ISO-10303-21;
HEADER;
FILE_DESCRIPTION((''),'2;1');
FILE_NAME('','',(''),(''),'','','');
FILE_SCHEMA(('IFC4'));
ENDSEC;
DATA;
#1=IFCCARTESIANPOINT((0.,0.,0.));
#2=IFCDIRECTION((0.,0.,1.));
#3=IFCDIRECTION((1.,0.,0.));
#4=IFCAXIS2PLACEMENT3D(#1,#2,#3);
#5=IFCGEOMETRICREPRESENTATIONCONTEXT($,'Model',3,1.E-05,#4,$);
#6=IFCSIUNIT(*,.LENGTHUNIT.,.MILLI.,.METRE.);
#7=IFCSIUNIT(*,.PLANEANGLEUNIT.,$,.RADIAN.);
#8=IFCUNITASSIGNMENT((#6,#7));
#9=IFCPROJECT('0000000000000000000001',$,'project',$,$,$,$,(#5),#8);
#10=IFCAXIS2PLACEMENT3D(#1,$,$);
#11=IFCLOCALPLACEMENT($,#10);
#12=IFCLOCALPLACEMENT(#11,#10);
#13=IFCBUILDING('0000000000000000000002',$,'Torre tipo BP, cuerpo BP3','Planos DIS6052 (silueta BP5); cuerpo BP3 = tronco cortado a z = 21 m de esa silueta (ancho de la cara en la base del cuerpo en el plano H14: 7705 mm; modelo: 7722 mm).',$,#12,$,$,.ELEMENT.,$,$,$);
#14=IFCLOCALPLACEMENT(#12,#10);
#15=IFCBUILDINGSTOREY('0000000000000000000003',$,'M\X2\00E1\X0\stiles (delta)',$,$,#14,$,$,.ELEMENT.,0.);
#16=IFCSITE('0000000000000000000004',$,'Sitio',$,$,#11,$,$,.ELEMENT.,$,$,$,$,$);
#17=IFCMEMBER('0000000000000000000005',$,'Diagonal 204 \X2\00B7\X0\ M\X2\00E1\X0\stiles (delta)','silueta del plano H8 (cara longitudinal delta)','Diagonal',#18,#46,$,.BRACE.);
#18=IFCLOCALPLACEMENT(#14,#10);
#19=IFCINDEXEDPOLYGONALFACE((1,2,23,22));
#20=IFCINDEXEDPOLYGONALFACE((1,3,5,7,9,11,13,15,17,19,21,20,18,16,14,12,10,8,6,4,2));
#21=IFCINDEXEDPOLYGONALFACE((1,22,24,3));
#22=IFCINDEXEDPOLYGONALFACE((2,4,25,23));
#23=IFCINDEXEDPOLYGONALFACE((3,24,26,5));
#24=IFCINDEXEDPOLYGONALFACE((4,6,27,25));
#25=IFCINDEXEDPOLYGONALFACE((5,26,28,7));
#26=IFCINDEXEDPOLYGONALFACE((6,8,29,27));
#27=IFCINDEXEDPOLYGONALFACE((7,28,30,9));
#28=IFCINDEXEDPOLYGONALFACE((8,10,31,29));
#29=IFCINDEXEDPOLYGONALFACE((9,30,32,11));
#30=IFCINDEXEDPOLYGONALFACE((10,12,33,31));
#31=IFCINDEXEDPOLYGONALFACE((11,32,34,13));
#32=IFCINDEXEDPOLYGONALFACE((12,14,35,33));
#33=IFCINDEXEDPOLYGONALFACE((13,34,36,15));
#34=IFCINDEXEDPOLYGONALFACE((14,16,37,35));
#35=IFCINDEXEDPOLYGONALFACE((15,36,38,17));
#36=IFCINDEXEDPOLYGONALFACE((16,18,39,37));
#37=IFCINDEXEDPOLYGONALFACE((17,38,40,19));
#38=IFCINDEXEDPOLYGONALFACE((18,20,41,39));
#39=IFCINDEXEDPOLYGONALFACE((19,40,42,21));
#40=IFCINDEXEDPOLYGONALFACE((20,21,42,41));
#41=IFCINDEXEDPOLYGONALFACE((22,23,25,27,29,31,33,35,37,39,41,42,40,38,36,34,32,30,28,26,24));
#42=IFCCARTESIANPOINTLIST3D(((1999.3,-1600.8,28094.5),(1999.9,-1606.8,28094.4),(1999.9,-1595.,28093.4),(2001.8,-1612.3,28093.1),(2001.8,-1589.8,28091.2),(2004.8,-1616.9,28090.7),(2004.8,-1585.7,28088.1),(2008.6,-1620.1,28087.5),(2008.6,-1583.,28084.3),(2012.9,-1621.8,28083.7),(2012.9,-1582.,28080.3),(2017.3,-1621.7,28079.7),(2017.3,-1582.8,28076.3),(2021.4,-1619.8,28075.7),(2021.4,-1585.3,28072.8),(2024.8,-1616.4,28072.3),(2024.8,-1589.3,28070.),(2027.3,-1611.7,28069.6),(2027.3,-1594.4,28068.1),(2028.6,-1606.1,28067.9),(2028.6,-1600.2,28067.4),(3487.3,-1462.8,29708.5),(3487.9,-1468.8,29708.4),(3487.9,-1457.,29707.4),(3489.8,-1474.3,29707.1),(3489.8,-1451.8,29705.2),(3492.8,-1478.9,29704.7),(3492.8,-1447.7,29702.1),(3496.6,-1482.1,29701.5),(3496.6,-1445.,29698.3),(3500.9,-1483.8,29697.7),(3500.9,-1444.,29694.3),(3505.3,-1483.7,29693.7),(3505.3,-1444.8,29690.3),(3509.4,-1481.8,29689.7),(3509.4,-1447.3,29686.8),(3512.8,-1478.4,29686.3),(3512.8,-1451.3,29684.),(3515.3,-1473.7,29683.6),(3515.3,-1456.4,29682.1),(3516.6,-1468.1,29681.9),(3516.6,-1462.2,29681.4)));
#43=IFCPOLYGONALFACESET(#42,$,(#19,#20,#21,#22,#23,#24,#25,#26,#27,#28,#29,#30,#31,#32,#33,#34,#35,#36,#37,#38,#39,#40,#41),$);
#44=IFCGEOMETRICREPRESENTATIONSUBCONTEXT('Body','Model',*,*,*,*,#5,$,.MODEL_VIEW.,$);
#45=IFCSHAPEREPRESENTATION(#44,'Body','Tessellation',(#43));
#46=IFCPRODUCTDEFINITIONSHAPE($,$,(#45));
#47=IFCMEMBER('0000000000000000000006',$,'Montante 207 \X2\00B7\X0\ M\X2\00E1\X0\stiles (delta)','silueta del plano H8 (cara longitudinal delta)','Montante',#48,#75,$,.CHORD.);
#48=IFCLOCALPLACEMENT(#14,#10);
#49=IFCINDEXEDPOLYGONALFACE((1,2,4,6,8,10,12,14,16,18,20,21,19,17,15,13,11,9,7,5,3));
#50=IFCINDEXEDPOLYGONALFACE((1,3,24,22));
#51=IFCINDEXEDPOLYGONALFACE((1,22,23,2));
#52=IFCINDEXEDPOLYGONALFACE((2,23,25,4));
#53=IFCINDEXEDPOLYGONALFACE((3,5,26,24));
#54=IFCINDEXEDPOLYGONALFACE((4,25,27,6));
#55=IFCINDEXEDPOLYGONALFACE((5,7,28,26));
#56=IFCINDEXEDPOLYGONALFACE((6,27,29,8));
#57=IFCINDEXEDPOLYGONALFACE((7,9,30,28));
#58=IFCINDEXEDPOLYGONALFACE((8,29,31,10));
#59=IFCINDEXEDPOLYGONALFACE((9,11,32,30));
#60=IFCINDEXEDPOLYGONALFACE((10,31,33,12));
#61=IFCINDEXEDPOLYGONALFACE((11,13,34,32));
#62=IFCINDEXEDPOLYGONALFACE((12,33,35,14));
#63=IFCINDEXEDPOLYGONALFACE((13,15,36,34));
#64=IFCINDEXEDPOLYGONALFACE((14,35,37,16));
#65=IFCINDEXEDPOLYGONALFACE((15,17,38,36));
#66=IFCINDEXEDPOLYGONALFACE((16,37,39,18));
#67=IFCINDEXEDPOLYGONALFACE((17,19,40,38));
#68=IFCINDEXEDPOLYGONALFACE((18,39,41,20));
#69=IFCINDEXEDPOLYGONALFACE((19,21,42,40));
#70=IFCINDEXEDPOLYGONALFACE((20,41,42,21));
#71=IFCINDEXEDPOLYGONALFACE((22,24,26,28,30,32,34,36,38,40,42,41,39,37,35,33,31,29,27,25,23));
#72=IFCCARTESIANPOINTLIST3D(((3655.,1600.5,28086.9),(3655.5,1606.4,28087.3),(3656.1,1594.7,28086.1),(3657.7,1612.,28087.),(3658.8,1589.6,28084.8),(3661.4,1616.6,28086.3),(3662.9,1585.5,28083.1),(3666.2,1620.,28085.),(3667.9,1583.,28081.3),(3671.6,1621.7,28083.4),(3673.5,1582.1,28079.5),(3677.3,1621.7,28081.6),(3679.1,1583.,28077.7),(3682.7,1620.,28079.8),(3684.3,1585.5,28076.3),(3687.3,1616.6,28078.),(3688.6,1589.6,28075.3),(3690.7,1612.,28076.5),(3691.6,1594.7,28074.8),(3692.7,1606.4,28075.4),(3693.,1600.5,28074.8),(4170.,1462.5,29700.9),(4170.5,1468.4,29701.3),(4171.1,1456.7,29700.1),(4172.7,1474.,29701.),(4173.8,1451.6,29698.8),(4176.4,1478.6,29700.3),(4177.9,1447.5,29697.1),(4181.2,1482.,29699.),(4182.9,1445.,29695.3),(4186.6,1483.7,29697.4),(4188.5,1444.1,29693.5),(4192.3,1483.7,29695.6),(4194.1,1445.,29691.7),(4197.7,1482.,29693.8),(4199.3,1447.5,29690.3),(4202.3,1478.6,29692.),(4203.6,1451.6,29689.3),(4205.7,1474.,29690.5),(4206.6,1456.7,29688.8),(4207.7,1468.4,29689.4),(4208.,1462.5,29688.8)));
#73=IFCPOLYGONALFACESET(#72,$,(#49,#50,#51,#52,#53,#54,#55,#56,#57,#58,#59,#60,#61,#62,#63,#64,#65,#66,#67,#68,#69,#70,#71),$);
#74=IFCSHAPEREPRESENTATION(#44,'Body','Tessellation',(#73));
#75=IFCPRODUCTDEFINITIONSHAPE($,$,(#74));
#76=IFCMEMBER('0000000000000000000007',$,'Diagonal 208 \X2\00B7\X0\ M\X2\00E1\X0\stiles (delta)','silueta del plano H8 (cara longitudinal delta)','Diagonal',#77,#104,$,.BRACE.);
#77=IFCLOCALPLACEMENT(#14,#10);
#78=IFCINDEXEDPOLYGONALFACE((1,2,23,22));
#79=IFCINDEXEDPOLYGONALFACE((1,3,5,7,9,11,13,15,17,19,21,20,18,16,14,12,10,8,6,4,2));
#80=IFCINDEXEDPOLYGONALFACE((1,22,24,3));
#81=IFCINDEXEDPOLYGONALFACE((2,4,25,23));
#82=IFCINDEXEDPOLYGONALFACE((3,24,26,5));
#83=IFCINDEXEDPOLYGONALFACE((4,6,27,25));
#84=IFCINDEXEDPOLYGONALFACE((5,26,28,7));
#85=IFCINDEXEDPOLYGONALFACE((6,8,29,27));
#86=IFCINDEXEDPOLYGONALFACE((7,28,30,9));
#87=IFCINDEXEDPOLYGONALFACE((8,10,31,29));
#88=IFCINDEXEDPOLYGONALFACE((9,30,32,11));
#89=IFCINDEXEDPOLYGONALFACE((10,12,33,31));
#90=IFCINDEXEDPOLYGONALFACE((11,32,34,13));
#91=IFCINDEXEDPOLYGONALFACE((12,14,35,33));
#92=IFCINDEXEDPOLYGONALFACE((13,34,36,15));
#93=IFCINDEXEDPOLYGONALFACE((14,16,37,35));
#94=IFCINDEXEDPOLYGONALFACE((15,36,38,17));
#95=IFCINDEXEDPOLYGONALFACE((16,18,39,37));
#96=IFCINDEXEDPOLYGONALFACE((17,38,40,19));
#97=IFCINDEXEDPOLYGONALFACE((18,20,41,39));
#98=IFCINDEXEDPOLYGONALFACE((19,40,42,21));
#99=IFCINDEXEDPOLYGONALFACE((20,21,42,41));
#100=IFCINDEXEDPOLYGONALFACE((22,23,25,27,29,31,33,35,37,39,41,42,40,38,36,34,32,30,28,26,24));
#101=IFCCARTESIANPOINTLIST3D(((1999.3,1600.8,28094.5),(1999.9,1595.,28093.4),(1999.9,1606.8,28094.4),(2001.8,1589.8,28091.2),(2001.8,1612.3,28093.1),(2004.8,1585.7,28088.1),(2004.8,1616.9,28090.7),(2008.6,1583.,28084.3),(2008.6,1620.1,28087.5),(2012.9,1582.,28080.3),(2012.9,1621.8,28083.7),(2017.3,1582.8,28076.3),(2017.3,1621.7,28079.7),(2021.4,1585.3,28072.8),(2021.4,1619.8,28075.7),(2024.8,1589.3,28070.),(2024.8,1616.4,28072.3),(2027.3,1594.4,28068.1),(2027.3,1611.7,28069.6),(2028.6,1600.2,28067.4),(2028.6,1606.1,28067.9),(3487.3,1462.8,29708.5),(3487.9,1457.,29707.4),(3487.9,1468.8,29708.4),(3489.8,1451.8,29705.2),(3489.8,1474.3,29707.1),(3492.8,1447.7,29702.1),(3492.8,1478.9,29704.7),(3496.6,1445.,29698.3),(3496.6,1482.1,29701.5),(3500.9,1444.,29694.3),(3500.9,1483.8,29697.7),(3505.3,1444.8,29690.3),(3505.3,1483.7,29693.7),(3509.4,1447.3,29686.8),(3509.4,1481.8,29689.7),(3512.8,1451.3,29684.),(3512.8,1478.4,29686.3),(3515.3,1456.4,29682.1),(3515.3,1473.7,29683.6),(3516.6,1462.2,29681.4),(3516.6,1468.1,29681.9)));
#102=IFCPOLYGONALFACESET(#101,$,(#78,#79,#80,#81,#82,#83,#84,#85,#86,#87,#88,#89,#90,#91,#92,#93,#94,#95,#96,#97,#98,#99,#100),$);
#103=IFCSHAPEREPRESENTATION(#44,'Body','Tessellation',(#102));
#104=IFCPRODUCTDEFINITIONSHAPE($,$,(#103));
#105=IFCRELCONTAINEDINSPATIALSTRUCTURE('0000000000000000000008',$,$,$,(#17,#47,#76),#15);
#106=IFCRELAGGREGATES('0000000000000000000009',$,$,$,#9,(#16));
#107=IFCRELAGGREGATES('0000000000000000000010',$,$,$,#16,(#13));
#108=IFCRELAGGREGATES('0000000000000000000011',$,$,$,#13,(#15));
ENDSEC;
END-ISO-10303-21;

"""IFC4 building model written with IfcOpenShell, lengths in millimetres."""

from ifc_helpers import new_model, si_unit, frame, origin, origin_with_axes, place, context, subcontext, project, spatial, circle, extrude, element, save


model = new_model("IFC4")

# Units and contexts
model_context = context("Model", 3, precision=1e-05, world=origin_with_axes())
body_context = subcontext(model_context, "Body", "Model", "MODEL_VIEW")
ifc_project = project(units=[si_unit("LENGTHUNIT", "METRE", prefix="MILLI"), si_unit("PLANEANGLEUNIT", "RADIAN")], contexts=[model_context])

# Site, building, storey
site_placement = place(None, origin())
site = spatial("IfcSite", under=ifc_project, at=site_placement, Name="Sitio", CompositionType="ELEMENT")
building_placement = place(site_placement, origin())
building = spatial("IfcBuilding", under=site, at=building_placement, Name="Torre tipo BP, cuerpo BP3", Description="Planos DIS6052 (silueta BP5); cuerpo BP3 = tronco cortado a z = 21 m de esa silueta (ancho de la cara en la base del cuerpo en el plano H14: 7705 mm; modelo: 7722 mm).", CompositionType="ELEMENT")
storey_placement = place(building_placement, origin())
storey = spatial("IfcBuildingStorey", under=building, at=storey_placement, Name="Mástiles (delta)", CompositionType="ELEMENT", Elevation=0.0)

# Members
member_1_placement = place(storey_placement, frame((3502.0, -1464.0, 29695.0), z_axis=(-0.676491, -0.062739, -0.733774), x_axis=(-0.736451, 0.057631, 0.674031)))
element("IfcMember", 1, at=member_1_placement, inside=storey, Name="Diagonal 204 · Mástiles (delta)", Description="silueta del plano H8 (cara longitudinal delta)", ObjectType="Diagonal", PredefinedType="BRACE", context=body_context, shape_type="SweptSolid", body=[
    extrude(circle(Radius=20.0), None, (0.0, 0.0, 1.0), 2199.6),
])
member_2_placement = place(storey_placement, frame((4189.0, 1464.0, 29695.0), z_axis=(-0.30298, 0.081187, -0.949533), x_axis=(-0.024679, -0.996699, -0.077345)))
element("IfcMember", 2, at=member_2_placement, inside=storey, Name="Montante 207 · Mástiles (delta)", Description="silueta del plano H8 (cara longitudinal delta)", ObjectType="Montante", PredefinedType="CHORD", context=body_context, shape_type="SweptSolid", body=[
    extrude(circle(Radius=20.0), None, (0.0, 0.0, 1.0), 1699.8),
])
member_3_placement = place(storey_placement, frame((3502.0, 1464.0, 29695.0), z_axis=(-0.676491, 0.062739, -0.733774), x_axis=(-0.736451, -0.057631, 0.674031)))
element("IfcMember", 3, at=member_3_placement, inside=storey, Name="Diagonal 208 · Mástiles (delta)", Description="silueta del plano H8 (cara longitudinal delta)", ObjectType="Diagonal", PredefinedType="BRACE", context=body_context, shape_type="SweptSolid", body=[
    extrude(circle(Radius=20.0), None, (0.0, 0.0, 1.0), 2199.6),
])

save(model, "model.ifc")
